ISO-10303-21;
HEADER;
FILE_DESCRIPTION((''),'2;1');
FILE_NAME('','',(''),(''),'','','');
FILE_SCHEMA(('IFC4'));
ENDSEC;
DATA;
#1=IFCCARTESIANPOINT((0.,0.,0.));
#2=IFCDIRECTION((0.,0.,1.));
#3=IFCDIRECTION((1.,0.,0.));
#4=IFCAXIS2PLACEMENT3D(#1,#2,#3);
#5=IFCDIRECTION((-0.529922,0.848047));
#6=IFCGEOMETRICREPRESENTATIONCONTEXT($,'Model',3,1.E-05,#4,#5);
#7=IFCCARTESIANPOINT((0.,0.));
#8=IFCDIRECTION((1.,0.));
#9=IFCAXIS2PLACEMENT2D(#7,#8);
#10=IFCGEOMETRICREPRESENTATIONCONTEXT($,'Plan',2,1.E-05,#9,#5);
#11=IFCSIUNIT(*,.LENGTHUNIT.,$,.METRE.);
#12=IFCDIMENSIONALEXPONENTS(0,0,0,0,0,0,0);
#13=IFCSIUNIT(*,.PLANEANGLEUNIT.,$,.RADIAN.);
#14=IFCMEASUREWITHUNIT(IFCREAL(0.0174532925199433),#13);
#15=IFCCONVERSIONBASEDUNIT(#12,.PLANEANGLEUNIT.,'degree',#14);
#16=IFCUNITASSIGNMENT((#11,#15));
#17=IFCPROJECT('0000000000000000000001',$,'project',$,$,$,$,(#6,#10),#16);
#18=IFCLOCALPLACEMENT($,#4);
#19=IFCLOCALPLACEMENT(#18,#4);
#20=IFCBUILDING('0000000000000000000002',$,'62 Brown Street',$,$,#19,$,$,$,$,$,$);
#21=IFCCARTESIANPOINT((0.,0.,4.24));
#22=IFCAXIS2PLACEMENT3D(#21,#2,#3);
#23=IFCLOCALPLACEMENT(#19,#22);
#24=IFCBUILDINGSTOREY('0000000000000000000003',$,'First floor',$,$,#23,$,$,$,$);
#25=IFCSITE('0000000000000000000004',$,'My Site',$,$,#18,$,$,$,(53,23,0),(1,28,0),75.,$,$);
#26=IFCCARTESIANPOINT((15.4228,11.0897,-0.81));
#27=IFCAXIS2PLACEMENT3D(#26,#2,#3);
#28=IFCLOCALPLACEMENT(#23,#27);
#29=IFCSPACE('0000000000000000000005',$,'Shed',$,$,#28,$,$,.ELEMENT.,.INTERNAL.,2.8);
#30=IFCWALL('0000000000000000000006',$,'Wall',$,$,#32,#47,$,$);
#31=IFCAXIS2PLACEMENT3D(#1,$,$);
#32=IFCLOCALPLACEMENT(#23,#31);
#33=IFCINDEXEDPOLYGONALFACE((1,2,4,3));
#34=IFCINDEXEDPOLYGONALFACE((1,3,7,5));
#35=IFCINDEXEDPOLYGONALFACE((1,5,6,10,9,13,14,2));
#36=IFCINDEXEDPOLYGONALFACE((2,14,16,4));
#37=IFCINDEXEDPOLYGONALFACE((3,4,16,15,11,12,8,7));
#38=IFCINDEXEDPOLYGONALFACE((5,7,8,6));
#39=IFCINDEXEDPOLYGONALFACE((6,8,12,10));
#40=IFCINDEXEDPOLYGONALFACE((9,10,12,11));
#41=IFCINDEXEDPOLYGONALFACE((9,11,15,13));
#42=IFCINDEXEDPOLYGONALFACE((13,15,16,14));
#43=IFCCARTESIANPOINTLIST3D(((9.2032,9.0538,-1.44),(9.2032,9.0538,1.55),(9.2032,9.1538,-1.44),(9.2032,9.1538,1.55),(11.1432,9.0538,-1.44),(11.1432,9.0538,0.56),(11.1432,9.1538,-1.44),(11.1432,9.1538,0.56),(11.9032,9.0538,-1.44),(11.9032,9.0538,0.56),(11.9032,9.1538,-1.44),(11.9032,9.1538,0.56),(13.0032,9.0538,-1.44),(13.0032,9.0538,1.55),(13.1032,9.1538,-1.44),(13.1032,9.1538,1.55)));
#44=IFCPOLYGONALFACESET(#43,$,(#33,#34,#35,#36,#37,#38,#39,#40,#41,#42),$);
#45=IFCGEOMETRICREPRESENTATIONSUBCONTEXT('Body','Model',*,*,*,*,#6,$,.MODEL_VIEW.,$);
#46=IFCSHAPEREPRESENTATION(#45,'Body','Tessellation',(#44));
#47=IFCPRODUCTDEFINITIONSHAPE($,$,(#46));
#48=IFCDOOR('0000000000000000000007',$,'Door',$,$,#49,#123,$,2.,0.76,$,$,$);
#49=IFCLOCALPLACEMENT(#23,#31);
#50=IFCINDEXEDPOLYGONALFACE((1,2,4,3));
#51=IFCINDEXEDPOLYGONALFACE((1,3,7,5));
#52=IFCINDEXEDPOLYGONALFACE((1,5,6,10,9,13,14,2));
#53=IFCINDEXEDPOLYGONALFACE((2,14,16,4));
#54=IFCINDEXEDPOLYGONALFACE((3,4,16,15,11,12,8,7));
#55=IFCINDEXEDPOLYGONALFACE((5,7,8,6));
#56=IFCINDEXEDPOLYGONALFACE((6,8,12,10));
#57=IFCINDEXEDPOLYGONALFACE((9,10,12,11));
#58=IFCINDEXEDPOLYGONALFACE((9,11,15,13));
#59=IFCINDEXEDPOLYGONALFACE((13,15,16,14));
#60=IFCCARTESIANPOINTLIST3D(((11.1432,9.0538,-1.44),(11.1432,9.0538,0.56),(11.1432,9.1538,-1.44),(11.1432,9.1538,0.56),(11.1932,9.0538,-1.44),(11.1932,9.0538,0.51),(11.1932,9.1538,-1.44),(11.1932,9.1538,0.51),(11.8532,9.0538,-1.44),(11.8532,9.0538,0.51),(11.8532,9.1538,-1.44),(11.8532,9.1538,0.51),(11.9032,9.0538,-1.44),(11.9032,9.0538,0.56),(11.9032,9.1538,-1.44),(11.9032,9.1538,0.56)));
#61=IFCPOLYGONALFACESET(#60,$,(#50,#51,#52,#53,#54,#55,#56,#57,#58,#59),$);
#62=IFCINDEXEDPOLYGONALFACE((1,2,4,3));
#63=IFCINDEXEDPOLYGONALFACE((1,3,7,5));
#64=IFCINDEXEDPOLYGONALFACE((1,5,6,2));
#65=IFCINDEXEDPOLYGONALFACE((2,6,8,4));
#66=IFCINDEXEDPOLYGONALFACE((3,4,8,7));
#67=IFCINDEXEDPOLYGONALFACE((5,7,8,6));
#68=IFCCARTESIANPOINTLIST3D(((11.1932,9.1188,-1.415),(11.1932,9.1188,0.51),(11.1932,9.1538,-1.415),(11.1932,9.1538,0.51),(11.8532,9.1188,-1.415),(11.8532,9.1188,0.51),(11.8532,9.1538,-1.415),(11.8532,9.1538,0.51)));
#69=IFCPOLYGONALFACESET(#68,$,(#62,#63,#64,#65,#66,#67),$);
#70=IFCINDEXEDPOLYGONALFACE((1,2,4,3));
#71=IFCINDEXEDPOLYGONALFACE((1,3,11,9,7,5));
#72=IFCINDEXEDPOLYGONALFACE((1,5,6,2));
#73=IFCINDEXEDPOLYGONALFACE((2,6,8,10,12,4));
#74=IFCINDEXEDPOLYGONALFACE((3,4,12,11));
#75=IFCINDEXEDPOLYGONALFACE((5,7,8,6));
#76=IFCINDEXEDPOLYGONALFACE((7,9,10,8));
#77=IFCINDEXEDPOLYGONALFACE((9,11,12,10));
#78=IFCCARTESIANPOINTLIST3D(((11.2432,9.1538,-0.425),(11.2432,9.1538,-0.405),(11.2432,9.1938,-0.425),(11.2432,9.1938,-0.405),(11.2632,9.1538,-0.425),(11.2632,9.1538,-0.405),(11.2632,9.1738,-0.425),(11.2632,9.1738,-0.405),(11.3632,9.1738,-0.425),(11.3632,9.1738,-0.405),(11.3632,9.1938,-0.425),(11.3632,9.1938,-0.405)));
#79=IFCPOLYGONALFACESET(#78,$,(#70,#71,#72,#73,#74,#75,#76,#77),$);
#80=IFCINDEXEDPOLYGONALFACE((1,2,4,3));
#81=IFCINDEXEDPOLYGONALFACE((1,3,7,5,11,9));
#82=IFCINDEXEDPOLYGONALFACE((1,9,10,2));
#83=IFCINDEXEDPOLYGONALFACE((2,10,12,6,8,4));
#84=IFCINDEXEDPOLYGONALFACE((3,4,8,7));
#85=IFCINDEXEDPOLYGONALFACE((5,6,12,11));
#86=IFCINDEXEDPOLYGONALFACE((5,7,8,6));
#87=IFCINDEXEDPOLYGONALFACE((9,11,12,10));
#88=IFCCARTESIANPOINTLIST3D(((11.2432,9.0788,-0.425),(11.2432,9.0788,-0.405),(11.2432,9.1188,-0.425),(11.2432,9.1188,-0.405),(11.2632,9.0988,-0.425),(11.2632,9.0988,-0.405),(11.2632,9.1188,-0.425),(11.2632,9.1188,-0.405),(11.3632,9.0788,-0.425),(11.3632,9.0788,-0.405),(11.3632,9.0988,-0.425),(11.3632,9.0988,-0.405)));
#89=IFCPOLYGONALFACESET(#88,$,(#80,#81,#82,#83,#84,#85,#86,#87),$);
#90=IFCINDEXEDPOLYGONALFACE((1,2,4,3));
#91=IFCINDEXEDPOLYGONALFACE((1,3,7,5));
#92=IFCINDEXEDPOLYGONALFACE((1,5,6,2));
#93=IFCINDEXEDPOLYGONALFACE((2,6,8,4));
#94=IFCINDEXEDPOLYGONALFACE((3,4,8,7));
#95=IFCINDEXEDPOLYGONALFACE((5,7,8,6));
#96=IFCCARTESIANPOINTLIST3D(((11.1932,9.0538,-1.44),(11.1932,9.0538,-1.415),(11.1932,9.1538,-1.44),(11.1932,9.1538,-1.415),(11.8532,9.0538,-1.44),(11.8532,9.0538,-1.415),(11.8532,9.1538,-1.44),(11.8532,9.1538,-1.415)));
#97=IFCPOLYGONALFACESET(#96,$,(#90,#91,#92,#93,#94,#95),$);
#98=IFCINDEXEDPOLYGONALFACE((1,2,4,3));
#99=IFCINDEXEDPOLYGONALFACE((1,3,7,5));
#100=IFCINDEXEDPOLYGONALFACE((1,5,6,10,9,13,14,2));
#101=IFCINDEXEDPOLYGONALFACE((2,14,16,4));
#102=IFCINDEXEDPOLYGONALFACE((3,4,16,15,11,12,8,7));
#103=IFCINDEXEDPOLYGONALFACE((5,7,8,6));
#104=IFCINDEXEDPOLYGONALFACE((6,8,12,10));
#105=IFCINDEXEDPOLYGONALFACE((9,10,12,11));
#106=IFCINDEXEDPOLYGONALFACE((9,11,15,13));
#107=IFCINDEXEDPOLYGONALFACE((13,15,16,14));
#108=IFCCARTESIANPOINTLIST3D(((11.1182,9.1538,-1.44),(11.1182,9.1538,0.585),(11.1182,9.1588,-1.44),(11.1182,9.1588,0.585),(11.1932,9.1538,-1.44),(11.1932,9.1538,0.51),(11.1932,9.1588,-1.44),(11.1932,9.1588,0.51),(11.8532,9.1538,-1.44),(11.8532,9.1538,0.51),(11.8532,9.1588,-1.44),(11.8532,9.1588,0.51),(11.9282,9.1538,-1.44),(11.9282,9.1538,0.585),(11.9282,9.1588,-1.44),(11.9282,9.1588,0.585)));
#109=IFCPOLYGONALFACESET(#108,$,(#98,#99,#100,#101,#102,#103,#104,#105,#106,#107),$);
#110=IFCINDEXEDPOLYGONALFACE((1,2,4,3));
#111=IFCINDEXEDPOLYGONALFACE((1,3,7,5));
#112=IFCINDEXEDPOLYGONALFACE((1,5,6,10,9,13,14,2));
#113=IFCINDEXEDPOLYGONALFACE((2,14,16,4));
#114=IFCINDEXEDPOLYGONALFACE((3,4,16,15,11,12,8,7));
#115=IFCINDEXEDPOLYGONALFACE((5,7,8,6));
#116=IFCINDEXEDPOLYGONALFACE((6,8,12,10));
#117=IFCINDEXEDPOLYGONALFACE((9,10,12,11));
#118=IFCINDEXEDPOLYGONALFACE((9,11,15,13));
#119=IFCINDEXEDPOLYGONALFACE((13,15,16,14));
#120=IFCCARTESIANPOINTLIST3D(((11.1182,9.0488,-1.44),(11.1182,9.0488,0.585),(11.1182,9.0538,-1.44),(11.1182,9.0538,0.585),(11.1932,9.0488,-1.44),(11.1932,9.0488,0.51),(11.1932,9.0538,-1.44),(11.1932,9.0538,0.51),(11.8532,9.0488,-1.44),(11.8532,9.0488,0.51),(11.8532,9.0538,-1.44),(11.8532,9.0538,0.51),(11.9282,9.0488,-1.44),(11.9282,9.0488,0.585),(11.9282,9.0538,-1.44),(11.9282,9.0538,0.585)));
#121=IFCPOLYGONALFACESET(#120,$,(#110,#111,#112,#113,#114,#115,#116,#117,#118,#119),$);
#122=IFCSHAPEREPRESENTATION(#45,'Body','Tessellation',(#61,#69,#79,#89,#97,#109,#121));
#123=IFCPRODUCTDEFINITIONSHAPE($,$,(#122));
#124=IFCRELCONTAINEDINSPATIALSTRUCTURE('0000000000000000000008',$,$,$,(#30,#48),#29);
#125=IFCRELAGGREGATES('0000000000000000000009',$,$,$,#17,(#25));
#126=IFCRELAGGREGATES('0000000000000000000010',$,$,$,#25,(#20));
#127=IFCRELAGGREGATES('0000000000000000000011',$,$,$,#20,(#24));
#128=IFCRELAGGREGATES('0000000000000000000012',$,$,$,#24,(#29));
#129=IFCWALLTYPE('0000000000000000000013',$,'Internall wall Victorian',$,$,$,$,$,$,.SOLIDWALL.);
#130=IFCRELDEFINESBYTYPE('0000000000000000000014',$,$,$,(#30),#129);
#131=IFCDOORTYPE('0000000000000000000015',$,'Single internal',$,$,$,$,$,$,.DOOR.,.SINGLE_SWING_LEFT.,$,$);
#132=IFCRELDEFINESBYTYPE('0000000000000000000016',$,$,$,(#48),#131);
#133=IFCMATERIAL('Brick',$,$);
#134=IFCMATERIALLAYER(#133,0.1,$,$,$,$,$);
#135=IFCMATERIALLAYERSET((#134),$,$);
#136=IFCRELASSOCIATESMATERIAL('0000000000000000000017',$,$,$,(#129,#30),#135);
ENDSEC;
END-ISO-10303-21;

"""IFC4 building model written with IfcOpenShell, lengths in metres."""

from ifc_helpers import new_model, entity, si_unit, converted_unit, direction, frame, origin_with_axes, origin_2d_with_axis, place, context, subcontext, project, spatial, line, indexed_curve, outline, extrude, clip, halfspace, shape, source, transform, mapped, material, layer, layer_set, layer_usage, type_object, type_shapes, element, fill, save


model = new_model("IFC4")

# Units and contexts
model_context = context("Model", 3, precision=1e-05, world=origin_with_axes(), true_north=direction((-0.529922, 0.848047)))
plan_context = context("Plan", 2, precision=1e-05, world=origin_2d_with_axis(), true_north=direction((-0.529922, 0.848047)))
body_context_1 = subcontext(model_context, "Body", "Model", "MODEL_VIEW")
body_context_2 = subcontext(plan_context, "Body", "Plan", "PLAN_VIEW")
ifc_project = project(units=[si_unit("LENGTHUNIT", "METRE"), converted_unit("PLANEANGLEUNIT", "degree", entity("IfcReal", 0.0174532925199433), si_unit("PLANEANGLEUNIT", "RADIAN"), dimensions=[0, 0, 0, 0, 0, 0, 0])], contexts=[model_context, plan_context])

# Site, building, storey, space
site_placement = place(None, origin_with_axes())
site = spatial("IfcSite", under=ifc_project, at=site_placement, Name="My Site", RefLatitude=(53, 23, 0), RefLongitude=(1, 28, 0), RefElevation=75.0)
building_placement = place(site_placement, origin_with_axes())
building = spatial("IfcBuilding", under=site, at=building_placement, Name="62 Brown Street")
storey_placement = place(building_placement, frame((0.0, 0.0, 4.24), z_axis=(0.0, 0.0, 1.0), x_axis=(1.0, 0.0, 0.0)))
storey = spatial("IfcBuildingStorey", under=building, at=storey_placement, Name="First floor")
space_placement = place(storey_placement, frame((15.4228, 11.0897, -0.81), z_axis=(0.0, 0.0, 1.0), x_axis=(1.0, 0.0, 0.0)))
space = spatial("IfcSpace", under=storey, at=space_placement, Name="Shed", CompositionType="ELEMENT", PredefinedType="INTERNAL", ElevationWithFlooring=2.8)

# Shared definitions
ifc_material_1 = material(Name="Brick")
ifc_layer_1 = layer(ifc_material_1, 0.1)
ifc_layer_set_1 = layer_set([ifc_layer_1])
wall_type_1 = type_object("IfcWallType", Name="Internall wall Victorian", PredefinedType="SOLIDWALL", material=ifc_layer_set_1)

# Wall, opening, door
ifc_layer_usage_1 = layer_usage(ifc_layer_set_1, "AXIS2", "POSITIVE", 0.0)
wall_1_placement = place(None, frame((13.1032, 9.1538, 2.8), z_axis=(0.0, 0.0, 1.0), x_axis=(-1.0, 0.0, 0.0)))
wall_1 = element("IfcWall", 1, at=wall_1_placement, inside=space, type_object=wall_type_1, material=ifc_layer_usage_1, Name="Wall", context=body_context_1, shape_type="Clipping", body=[
    clip(extrude(outline(indexed_curve([(0.0, 0.0), (0.0, 0.1), (3.9, 0.1), (3.9, 0.0), (0.0, 0.0)], self_intersect=False)), origin_with_axes(), (0.0, 0.0, 1.0), 2.99), halfspace(frame((0.0, 0.0, -2.8), z_axis=(-0.707104, 0.70711, 0.0), x_axis=(0.70711, 0.707104, 0.0)), False)),
])
shared_shape_1 = source(origin_with_axes(), body_context_1, "Body", "SweptSolid", [
    extrude(outline(indexed_curve([(0.0, 0.0), (0.76, 0.0), (0.76, 2.0), (0.0, 2.0)], segments=[line(1, 2, 3, 4, 1)])), frame((0.0, -0.6, 0.0), z_axis=(0.0, -1.0, 0.0), x_axis=(1.0, 0.0, 0.0)), (0.0, 0.0, -1.0), 1.2),
])
opening_placement = place(wall_1_placement, frame((1.2, 0.0, 0.0), z_axis=(0.0, 0.0, 1.0), x_axis=(1.0, 0.0, 0.0)))
opening = element("IfcOpeningElement", 2, at=opening_placement, cuts=wall_1, PredefinedType="OPENING", context=body_context_1, shape_type="MappedRepresentation", body=[
    mapped(shared_shape_1, transform((0.0, 0.0, 0.0), x_axis=(1.0, 0.0, 0.0), y_axis=(0.0, 1.0, 0.0), z_axis=(0.0, 0.0, 1.0), scale=1.0)),
])
door_type = type_object("IfcDoorType", Name="Single internal", OperationType="SINGLE_SWING_LEFT", PredefinedType="DOOR")
shared_shape_2 = source(origin_with_axes(), body_context_1, "Body", "SweptSolid", [
    extrude(outline(indexed_curve([(0.0, 0.0), (0.0, 2.0), (0.76, 2.0), (0.76, 0.0), (0.71, 0.0), (0.71, 1.95), (0.05, 1.95), (0.05, 0.0)], segments=[line(1, 2, 3, 4, 5, 6, 7, 8, 1)])), frame((0.0, 0.0, 0.0), z_axis=(0.0, -1.0, 0.0), x_axis=(1.0, 0.0, 0.0)), (0.0, 0.0, -1.0), 0.1),
    extrude(outline(indexed_curve([(0.0, 0.0), (0.66, 0.0), (0.66, 0.035), (0.0, 0.035)], segments=[line(1, 2, 3, 4, 1)])), frame((0.05, 0.0, 0.025), z_axis=(0.0, 0.0, 1.0), x_axis=(1.0, 0.0, 0.0)), (0.0, 0.0, 1.0), 1.925),
    extrude(outline(indexed_curve([(0.0, 0.0), (0.0, -0.04), (-0.12, -0.04), (-0.12, -0.02), (-0.02, -0.02), (-0.02, 0.0)], segments=[line(1, 2, 3, 4, 5, 6, 1)])), frame((0.66, 0.0, 1.015), z_axis=(0.0, 0.0, 1.0), x_axis=(1.0, 0.0, 0.0)), (0.0, 0.0, 1.0), 0.02),
    extrude(outline(indexed_curve([(0.0, 0.0), (0.0, 0.04), (-0.12, 0.04), (-0.12, 0.02), (-0.02, 0.02), (-0.02, 0.0)], segments=[line(1, 2, 3, 4, 5, 6, 1)])), frame((0.66, 0.035, 1.015), z_axis=(0.0, 0.0, 1.0), x_axis=(1.0, 0.0, 0.0)), (0.0, 0.0, 1.0), 0.02),
    extrude(outline(indexed_curve([(0.0, 0.0), (0.66, 0.0), (0.66, 0.1), (0.0, 0.1)], segments=[line(1, 2, 3, 4, 1)])), frame((0.05, 0.0, 0.0), z_axis=(0.0, 0.0, 1.0), x_axis=(1.0, 0.0, 0.0)), (0.0, 0.0, 1.0), 0.025),
    extrude(outline(indexed_curve([(0.0, 0.0), (0.0, 2.025), (0.81, 2.025), (0.81, 0.0), (0.735, 0.0), (0.735, 1.95), (0.075, 1.95), (0.075, 0.0)], segments=[line(1, 2, 3, 4, 5, 6, 7, 8, 1)])), frame((-0.025, -0.005, 0.0), z_axis=(0.0, -1.0, 0.0), x_axis=(1.0, 0.0, 0.0)), (0.0, 0.0, -1.0), 0.005),
    extrude(outline(indexed_curve([(0.0, 0.0), (0.0, 2.025), (0.81, 2.025), (0.81, 0.0), (0.735, 0.0), (0.735, 1.95), (0.075, 1.95), (0.075, 0.0)], segments=[line(1, 2, 3, 4, 5, 6, 7, 8, 1)])), frame((-0.025, 0.1, 0.0), z_axis=(0.0, -1.0, 0.0), x_axis=(1.0, 0.0, 0.0)), (0.0, 0.0, -1.0), 0.005),
])
shared_shape_3 = source(origin_with_axes(), body_context_2, "Body", "Curve2D", [
    entity("IfcIndexedPolyCurve", entity("IfcCartesianPointList2D", [[0.0, 0.0], [0.05, 0.0], [0.05, 0.1], [0.0, 0.1]]), [entity("IfcLineIndex", [1, 2, 3, 4, 1])]),
    entity("IfcIndexedPolyCurve", entity("IfcCartesianPointList2D", [[0.76, 0.0], [0.71, 0.0], [0.71, 0.1], [0.76, 0.1]]), [entity("IfcLineIndex", [1, 2, 3, 4, 1])]),
    entity("IfcTrimmedCurve", entity("IfcEllipse", entity("IfcAxis2Placement2D", entity("IfcCartesianPoint", [0.085, 0.1]), entity("IfcDirection", [1.0, 0.0])), 0.625, 0.66), [entity("IfcCartesianPoint", [0.71, 0.1])], [entity("IfcCartesianPoint", [0.085, 0.76])], True, "CARTESIAN"),
    entity("IfcIndexedPolyCurve", entity("IfcCartesianPointList2D", [[0.05, 0.1], [0.085, 0.1], [0.085, 0.76], [0.05, 0.76]]), [entity("IfcLineIndex", [1, 2, 3, 4, 1])]),
])
type_shapes(door_type, [shared_shape_2, shared_shape_3])
door_placement = place(opening_placement, frame((0.0, 0.0, 0.0), z_axis=(0.0, 0.0, 1.0), x_axis=(1.0, 0.0, 0.0)))
door = element("IfcDoor", 3, at=door_placement, inside=space, type_object=door_type, Name="Door", OverallHeight=2.0, OverallWidth=0.76, shapes=[
    shape(body_context_1, "Body", "MappedRepresentation", [mapped(shared_shape_2, transform((0.0, 0.0, 0.0), x_axis=(1.0, 0.0, 0.0), y_axis=(0.0, 1.0, 0.0), z_axis=(0.0, 0.0, 1.0), scale=1.0))]),
    shape(body_context_2, "Body", "MappedRepresentation", [mapped(shared_shape_3, transform((0.0, 0.0, 0.0), x_axis=(1.0, 0.0, 0.0), y_axis=(0.0, 1.0, 0.0), z_axis=(0.0, 0.0, 1.0), scale=1.0))]),
])
fill(opening, door)

save(model, "model.ifc")
